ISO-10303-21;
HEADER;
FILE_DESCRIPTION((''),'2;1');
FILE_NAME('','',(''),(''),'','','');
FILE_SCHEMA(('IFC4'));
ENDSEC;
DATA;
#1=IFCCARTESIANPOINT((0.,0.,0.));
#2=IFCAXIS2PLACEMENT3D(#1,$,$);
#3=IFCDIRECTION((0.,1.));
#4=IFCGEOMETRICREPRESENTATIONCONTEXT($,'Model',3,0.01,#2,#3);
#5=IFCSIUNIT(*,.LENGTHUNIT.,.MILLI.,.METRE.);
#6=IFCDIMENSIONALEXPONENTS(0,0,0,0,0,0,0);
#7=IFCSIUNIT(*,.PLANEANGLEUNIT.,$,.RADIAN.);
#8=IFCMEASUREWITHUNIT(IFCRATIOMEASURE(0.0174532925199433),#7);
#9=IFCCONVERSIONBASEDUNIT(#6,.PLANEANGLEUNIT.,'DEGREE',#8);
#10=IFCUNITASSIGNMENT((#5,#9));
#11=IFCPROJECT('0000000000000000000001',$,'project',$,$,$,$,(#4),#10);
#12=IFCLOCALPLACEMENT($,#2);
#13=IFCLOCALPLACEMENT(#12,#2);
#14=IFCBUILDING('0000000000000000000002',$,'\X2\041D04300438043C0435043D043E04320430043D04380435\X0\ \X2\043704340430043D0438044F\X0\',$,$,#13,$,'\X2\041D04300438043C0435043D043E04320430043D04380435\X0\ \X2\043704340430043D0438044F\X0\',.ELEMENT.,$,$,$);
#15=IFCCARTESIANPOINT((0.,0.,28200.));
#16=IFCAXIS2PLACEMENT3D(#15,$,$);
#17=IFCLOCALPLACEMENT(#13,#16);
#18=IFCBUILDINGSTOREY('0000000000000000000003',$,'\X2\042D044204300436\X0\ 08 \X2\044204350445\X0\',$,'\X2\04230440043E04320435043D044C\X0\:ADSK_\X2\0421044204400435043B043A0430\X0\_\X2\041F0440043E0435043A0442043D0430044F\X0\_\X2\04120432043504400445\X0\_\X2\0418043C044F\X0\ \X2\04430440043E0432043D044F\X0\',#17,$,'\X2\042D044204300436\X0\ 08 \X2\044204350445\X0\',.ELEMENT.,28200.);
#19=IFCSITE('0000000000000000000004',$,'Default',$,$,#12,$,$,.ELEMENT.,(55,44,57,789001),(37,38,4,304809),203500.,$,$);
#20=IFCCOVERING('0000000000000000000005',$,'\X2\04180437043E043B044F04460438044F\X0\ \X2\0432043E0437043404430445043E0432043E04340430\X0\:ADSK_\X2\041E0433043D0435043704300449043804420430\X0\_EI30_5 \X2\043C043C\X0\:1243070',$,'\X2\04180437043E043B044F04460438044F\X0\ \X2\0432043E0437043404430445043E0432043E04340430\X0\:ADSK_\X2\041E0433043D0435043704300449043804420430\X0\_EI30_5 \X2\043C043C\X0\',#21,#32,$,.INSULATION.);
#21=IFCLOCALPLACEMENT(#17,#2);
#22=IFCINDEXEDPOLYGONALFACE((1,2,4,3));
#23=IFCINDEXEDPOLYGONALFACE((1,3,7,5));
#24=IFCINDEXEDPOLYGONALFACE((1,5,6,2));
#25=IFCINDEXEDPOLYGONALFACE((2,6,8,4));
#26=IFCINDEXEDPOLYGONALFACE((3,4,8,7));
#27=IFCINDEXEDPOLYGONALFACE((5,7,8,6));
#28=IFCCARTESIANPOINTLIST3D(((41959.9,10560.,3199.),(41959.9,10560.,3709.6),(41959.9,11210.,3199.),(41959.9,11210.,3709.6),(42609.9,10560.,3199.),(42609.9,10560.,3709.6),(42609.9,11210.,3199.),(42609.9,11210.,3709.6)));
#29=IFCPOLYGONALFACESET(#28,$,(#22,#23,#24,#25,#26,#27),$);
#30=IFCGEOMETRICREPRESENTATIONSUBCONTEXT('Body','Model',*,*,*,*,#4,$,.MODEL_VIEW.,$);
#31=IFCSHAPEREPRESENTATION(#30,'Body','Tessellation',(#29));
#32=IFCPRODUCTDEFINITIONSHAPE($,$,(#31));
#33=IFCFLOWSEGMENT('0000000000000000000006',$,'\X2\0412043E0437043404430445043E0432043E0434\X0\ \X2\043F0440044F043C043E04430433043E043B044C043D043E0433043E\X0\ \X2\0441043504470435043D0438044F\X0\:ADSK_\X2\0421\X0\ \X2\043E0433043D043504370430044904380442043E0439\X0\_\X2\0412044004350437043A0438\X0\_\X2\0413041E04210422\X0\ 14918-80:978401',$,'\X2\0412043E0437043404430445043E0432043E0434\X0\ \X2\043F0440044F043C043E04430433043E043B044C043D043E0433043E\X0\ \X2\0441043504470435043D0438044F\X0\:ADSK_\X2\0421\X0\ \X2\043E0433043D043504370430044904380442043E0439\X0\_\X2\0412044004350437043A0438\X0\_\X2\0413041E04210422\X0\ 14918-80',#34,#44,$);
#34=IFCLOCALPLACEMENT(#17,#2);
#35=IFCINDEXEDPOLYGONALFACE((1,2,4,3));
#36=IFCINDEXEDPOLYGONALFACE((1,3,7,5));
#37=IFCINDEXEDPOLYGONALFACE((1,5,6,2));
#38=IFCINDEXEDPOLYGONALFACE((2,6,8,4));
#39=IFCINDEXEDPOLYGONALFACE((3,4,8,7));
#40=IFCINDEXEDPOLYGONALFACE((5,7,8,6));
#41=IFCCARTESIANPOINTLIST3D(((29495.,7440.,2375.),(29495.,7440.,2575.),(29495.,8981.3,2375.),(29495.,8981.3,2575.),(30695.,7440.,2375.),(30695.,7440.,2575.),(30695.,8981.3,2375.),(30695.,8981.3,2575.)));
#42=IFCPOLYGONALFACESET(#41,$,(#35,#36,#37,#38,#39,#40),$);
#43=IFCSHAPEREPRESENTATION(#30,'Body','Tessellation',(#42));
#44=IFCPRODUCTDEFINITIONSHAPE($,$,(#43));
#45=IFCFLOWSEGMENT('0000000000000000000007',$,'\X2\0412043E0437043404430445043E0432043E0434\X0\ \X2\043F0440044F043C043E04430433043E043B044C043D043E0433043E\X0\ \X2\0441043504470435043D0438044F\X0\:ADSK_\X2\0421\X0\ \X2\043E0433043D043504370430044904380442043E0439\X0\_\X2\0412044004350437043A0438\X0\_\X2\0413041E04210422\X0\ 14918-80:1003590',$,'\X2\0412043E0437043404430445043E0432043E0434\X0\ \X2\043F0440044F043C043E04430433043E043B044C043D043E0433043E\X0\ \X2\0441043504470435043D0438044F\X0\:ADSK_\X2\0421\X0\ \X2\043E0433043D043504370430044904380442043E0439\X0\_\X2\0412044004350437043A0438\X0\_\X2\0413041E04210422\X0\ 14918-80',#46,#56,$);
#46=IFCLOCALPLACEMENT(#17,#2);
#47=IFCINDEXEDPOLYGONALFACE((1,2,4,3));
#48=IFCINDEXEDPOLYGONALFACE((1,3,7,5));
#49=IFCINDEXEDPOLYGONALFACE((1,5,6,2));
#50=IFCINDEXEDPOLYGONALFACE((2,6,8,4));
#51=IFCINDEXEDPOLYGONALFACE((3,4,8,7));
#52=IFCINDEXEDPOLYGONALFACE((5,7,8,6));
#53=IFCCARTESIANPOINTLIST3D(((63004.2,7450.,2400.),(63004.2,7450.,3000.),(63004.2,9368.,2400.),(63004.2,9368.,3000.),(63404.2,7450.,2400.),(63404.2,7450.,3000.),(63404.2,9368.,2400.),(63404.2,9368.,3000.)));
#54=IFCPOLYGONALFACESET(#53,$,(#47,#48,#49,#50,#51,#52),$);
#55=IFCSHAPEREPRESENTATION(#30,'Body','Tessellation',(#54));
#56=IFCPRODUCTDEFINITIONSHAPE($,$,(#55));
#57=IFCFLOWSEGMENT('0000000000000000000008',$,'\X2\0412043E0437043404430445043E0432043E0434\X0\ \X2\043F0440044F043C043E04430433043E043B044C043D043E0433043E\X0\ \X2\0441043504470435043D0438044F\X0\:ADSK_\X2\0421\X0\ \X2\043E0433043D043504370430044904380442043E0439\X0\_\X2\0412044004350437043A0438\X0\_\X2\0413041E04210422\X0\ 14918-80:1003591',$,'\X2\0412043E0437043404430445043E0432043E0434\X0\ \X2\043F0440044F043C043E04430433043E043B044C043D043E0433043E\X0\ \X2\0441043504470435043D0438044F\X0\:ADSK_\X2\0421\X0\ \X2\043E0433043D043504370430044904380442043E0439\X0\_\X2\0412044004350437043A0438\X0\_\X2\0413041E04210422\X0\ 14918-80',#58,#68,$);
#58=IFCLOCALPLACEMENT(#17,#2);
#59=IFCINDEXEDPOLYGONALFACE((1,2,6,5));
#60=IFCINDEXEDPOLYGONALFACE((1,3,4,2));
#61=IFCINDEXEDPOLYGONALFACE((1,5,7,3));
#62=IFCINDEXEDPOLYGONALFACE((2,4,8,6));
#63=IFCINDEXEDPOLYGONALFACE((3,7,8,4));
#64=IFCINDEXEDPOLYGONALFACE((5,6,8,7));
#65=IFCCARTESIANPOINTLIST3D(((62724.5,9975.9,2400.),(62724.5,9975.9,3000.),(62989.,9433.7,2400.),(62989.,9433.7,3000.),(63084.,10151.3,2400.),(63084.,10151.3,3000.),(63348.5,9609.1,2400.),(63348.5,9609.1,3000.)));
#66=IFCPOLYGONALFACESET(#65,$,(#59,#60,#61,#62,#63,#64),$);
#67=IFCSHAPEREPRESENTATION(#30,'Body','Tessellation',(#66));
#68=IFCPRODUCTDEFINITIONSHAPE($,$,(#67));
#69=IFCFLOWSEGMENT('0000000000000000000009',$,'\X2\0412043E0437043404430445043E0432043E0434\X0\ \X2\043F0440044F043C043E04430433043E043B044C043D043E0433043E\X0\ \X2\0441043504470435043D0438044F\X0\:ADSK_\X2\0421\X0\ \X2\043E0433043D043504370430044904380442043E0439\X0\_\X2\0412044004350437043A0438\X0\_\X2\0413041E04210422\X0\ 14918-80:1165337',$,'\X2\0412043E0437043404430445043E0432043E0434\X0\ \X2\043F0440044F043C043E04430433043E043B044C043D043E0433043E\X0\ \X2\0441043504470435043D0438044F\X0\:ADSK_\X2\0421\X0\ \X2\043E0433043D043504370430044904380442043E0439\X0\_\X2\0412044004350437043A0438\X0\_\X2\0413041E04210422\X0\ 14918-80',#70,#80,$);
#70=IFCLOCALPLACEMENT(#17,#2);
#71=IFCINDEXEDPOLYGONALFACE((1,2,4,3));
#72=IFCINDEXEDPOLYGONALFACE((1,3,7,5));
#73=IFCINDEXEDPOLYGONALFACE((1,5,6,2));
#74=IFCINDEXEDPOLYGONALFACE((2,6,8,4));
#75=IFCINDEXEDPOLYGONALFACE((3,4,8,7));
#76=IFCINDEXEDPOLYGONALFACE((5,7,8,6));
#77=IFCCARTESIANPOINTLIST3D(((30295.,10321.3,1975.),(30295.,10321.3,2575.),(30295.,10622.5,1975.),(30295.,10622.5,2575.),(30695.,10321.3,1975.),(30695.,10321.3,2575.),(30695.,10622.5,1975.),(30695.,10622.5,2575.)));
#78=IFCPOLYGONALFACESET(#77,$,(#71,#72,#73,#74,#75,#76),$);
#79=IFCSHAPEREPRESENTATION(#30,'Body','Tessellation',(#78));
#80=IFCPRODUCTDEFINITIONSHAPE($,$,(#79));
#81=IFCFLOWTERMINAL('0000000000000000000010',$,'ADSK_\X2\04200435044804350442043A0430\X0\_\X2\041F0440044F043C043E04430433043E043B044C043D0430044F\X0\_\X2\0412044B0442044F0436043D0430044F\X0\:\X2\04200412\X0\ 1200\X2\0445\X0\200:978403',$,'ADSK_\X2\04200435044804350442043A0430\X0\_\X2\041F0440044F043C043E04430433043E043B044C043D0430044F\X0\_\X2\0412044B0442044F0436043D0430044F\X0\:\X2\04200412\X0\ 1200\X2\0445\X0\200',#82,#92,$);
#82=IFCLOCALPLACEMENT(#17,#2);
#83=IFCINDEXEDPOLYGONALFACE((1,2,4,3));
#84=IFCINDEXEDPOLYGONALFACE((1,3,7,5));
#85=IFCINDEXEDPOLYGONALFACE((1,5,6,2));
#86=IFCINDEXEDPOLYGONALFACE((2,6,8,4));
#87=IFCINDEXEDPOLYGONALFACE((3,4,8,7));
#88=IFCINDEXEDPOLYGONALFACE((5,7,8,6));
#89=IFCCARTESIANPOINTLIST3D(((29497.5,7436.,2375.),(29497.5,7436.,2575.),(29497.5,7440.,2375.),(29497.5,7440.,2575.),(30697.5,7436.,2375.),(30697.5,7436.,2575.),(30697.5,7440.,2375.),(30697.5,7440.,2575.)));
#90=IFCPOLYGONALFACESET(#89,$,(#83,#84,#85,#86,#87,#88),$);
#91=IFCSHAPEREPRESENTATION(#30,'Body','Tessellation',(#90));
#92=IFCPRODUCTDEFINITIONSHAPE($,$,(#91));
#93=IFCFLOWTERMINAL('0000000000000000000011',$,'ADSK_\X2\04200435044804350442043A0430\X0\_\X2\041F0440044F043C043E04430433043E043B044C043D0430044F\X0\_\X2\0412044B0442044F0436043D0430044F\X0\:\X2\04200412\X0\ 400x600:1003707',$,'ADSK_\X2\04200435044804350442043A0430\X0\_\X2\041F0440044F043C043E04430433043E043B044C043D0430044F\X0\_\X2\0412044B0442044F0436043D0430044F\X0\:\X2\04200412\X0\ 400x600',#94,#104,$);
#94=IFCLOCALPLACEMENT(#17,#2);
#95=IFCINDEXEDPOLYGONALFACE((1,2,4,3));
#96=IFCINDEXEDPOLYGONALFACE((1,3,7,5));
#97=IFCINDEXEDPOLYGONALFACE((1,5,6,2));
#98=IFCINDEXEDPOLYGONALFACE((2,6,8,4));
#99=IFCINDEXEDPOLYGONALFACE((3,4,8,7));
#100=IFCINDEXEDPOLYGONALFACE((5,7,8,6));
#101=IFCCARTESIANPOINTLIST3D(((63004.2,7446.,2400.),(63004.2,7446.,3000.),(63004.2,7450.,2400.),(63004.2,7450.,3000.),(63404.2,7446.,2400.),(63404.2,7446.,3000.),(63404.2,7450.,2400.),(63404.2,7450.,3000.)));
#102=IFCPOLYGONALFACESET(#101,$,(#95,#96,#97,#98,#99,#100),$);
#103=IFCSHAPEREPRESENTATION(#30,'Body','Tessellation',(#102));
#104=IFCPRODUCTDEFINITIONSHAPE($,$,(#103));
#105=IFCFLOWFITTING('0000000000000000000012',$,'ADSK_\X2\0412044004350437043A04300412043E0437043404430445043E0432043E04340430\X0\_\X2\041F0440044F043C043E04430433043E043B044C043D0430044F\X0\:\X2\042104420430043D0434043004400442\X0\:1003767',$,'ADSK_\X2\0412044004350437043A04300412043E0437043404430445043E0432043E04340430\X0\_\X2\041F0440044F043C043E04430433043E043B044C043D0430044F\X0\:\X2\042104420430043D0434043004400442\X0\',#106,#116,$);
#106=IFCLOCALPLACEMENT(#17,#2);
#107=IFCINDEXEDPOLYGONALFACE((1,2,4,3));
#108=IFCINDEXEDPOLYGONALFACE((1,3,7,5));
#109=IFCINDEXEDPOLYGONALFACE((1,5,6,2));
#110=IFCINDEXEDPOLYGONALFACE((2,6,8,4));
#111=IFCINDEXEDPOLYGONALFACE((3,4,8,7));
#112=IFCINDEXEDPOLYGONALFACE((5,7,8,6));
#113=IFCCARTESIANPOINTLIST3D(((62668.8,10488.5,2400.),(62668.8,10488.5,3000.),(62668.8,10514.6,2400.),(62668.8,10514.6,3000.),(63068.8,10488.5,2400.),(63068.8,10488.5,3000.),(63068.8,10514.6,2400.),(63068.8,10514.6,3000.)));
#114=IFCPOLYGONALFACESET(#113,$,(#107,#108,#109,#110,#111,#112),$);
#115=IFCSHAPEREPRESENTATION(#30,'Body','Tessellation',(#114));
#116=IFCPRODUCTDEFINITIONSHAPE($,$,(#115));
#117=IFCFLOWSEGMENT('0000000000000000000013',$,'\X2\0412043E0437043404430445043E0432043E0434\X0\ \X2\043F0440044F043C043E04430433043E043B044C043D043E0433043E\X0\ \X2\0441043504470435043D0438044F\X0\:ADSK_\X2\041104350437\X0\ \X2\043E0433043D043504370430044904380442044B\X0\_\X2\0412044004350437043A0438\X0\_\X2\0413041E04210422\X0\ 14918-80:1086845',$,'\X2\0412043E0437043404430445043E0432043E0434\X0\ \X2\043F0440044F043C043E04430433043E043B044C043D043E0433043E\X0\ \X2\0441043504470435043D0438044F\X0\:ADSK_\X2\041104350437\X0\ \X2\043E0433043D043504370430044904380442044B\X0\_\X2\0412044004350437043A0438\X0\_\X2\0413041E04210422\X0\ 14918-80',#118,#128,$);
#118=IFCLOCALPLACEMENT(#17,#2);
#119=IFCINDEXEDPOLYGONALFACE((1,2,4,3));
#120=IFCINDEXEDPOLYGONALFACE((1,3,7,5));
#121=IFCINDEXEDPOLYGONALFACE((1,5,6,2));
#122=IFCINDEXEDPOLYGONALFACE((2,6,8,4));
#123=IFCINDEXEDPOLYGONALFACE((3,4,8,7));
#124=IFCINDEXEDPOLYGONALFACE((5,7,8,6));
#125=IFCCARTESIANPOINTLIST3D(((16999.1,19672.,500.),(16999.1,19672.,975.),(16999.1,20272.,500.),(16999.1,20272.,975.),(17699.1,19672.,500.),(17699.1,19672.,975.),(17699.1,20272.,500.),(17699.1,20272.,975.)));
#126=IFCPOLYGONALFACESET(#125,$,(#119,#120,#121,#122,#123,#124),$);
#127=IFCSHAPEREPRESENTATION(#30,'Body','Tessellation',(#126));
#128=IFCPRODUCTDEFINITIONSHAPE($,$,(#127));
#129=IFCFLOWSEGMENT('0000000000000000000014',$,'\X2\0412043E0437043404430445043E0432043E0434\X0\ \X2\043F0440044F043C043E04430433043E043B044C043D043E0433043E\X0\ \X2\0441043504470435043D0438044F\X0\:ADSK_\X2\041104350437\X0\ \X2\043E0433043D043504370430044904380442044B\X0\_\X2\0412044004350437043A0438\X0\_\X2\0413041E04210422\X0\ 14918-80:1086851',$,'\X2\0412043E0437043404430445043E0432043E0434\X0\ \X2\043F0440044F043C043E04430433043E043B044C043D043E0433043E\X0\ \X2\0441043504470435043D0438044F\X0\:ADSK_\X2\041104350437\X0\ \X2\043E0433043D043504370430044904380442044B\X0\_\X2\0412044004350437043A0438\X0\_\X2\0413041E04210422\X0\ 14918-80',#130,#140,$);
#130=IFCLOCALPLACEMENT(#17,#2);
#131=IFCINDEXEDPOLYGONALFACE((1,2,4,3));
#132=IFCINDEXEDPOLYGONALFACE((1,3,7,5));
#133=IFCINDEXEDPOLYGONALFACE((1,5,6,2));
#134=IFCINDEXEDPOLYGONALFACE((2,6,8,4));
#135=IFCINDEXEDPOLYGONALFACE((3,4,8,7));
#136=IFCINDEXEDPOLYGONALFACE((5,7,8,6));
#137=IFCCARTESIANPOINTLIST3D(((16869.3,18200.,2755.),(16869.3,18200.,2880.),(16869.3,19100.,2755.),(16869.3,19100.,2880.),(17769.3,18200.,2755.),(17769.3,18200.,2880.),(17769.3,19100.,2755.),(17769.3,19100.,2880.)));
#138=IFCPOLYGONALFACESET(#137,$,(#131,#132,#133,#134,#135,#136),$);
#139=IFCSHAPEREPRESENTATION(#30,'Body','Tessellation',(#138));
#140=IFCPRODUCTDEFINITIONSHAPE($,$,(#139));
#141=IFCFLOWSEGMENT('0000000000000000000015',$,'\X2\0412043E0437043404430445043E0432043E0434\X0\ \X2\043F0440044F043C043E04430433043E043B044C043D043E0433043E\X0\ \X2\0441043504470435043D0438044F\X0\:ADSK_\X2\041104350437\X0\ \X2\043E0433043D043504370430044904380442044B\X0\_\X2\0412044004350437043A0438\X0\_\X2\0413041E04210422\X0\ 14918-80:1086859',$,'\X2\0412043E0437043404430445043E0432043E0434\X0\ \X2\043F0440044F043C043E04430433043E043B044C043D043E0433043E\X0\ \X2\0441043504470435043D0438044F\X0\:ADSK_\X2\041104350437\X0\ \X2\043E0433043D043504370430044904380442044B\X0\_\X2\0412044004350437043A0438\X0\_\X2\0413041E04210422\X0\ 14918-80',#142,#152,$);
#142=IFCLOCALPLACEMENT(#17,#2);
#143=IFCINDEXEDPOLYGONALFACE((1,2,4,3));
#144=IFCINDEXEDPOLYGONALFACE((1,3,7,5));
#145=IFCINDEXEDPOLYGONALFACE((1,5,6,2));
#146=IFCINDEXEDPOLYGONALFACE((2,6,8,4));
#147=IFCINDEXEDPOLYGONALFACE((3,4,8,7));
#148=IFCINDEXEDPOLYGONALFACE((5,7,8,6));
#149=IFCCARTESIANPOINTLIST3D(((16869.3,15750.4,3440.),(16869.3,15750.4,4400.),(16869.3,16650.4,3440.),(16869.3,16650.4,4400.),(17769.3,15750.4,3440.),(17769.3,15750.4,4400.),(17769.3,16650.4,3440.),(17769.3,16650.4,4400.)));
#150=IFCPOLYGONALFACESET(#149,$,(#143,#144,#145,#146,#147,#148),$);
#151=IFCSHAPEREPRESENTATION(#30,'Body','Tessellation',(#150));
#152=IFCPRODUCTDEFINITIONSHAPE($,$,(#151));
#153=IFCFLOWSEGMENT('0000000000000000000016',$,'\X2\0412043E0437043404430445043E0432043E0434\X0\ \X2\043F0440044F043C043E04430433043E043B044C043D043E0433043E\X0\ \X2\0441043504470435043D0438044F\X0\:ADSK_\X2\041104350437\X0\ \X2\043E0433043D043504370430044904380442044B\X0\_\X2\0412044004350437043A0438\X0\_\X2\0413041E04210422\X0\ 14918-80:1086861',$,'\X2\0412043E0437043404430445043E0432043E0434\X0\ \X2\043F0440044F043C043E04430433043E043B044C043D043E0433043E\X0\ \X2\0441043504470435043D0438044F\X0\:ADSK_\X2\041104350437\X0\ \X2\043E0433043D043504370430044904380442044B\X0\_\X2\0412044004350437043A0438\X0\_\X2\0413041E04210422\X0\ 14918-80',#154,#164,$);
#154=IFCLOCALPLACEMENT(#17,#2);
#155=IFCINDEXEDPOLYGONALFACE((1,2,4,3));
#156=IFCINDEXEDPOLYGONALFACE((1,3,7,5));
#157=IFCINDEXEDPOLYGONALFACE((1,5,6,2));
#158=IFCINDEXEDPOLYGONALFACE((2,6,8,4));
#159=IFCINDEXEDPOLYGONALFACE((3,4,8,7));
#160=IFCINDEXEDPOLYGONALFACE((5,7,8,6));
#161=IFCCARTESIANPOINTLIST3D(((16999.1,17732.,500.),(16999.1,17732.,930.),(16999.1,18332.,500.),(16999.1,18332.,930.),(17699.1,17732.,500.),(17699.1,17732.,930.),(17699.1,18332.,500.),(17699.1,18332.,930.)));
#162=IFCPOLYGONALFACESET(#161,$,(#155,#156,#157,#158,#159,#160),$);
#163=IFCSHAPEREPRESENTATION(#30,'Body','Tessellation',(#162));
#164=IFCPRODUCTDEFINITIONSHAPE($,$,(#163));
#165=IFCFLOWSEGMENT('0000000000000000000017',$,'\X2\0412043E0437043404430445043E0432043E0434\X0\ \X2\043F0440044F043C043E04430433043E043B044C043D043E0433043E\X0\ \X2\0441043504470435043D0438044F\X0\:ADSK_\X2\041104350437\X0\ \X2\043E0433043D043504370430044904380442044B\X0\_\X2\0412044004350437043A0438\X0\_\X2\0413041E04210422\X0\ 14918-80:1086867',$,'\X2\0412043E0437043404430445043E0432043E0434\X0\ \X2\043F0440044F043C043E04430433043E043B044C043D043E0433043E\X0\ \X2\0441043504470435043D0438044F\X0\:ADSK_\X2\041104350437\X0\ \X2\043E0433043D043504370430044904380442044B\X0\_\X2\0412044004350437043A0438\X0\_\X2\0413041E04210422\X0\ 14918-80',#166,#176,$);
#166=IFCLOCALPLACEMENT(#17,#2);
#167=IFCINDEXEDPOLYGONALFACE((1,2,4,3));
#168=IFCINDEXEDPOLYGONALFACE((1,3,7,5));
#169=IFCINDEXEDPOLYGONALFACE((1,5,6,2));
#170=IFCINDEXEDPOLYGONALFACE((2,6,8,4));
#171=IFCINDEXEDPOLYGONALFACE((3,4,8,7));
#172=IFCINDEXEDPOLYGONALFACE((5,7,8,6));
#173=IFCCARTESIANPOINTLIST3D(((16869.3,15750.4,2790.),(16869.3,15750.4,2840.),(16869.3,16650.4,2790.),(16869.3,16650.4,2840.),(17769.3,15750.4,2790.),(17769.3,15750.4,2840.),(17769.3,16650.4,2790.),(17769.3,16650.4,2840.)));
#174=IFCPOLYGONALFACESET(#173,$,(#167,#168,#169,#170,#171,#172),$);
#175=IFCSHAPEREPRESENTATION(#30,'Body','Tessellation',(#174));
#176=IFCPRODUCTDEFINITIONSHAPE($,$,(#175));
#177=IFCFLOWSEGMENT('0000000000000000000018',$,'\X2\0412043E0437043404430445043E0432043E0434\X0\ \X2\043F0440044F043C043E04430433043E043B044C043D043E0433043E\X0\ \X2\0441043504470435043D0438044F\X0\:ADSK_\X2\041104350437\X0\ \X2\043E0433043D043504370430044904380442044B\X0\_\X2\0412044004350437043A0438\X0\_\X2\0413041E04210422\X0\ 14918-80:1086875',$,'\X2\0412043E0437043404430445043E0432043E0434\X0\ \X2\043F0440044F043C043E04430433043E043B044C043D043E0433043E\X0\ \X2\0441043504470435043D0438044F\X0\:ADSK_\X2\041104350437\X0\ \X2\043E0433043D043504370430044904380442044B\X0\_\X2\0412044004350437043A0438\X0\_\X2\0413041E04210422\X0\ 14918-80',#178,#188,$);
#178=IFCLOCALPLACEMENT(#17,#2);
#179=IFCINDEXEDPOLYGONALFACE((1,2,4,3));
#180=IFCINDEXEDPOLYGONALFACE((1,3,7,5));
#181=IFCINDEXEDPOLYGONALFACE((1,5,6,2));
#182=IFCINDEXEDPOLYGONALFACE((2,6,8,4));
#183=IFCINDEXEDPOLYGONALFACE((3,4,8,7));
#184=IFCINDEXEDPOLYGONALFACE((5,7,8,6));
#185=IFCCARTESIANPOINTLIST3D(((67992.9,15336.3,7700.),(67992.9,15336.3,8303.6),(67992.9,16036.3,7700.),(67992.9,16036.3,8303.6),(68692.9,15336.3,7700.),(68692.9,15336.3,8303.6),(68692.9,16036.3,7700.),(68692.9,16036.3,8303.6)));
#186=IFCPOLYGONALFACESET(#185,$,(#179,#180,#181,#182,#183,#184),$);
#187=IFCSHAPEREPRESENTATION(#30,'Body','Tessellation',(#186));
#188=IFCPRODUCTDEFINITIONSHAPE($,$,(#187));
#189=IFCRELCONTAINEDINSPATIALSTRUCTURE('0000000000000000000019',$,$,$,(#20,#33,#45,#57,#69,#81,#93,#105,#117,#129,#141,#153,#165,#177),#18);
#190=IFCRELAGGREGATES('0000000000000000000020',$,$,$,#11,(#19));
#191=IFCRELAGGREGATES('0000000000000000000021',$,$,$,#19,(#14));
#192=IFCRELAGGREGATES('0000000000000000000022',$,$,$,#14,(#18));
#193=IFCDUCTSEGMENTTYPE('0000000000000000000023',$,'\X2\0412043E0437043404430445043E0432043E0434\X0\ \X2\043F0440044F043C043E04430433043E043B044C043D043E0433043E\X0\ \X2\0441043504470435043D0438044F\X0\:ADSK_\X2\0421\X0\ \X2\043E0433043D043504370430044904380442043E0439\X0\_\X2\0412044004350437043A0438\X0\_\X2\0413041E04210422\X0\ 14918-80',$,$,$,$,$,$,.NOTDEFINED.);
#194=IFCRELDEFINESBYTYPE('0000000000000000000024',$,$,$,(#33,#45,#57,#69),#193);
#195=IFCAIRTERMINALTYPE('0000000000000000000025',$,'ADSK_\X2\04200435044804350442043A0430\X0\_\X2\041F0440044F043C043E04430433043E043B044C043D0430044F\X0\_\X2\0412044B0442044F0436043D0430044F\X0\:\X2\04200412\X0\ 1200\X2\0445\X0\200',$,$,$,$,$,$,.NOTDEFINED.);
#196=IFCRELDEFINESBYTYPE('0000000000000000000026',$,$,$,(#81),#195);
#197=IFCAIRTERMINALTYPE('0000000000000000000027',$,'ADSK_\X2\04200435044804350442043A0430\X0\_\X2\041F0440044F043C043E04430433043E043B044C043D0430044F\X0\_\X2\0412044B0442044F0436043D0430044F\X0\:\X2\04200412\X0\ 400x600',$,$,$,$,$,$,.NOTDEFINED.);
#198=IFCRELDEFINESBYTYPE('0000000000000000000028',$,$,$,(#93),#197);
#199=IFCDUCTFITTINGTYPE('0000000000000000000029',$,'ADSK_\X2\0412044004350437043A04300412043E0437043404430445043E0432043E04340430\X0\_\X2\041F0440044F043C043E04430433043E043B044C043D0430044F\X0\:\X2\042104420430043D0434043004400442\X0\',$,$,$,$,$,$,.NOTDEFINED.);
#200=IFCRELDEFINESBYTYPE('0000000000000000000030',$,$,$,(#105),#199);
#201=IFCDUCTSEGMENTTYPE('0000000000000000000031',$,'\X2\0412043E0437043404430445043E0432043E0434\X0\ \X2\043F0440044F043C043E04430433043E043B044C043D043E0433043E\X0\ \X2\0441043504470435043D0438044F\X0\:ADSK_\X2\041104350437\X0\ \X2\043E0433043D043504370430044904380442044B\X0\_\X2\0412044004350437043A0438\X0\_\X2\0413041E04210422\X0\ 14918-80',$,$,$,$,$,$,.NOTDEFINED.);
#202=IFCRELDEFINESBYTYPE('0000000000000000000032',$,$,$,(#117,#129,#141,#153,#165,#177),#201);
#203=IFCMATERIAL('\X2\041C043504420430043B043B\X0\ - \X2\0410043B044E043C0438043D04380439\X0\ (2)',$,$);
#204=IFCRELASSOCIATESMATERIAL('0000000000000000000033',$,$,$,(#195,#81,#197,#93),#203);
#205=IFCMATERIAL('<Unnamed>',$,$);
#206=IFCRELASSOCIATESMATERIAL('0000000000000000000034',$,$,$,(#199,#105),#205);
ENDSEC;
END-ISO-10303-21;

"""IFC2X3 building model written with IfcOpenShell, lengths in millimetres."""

from ifc_helpers import new_model, entity, si_unit, converted_unit, direction, frame, frame_2d, origin, origin_2d_with_axis, place, context, subcontext, project, spatial, rectangle, extrude, source, transform, mapped, material, type_object, type_shapes, element, save


model = new_model("IFC2X3")

# Units and contexts
model_context = context("Model", 3, precision=0.01, world=origin(), true_north=direction((0.0, 1.0)))
body_context = subcontext(model_context, "Body", "Model", "MODEL_VIEW")
ifc_project = project(units=[si_unit("LENGTHUNIT", "METRE", prefix="MILLI"), converted_unit("PLANEANGLEUNIT", "DEGREE", entity("IfcRatioMeasure", 0.0174532925199433), si_unit("PLANEANGLEUNIT", "RADIAN"), dimensions=[0, 0, 0, 0, 0, 0, 0])], contexts=[model_context])

# Site, building, storey
site_placement = place(None, frame((0.0, 0.0, 0.0)))
site = spatial("IfcSite", under=ifc_project, at=site_placement, Name="Default", CompositionType="ELEMENT", RefLatitude=(55, 44, 57, 789001), RefLongitude=(37, 38, 4, 304809), RefElevation=203500.0)
building_placement = place(site_placement, origin())
building = spatial("IfcBuilding", under=site, at=building_placement, Name="Наименование здания", LongName="Наименование здания", CompositionType="ELEMENT")
storey_placement = place(building_placement, frame((0.0, 0.0, 28200.0)))
storey = spatial("IfcBuildingStorey", under=building, at=storey_placement, Name="Этаж 08 тех", ObjectType="Уровень:ADSK_Стрелка_Проектная_Вверх_Имя уровня", LongName="Этаж 08 тех", CompositionType="ELEMENT", Elevation=28200.0)

# Covering
covering_1_placement = place(storey_placement, frame((41959.9, 10560.0, 3199.0)))
element("IfcCovering", 1, at=covering_1_placement, inside=storey, Name="Изоляция воздуховода:ADSK_Огнезащита_EI30_5 мм:1243070", ObjectType="Изоляция воздуховода:ADSK_Огнезащита_EI30_5 мм", PredefinedType="INSULATION", context=body_context, shape_type="SweptSolid", body=[
    extrude(rectangle(XDim=650.0, YDim=650.0, at=origin_2d_with_axis()), frame((325.0, 325.0, 0.0), z_axis=(0.0, 0.0, 1.0), x_axis=(-1.0, 0.0, 0.0)), (0.0, 0.0, 1.0), 510.6),
])

# Flow segments
duct_segment_type_1 = type_object("IfcDuctSegmentType", Name="Воздуховод прямоугольного сечения:ADSK_С огнезащитой_Врезки_ГОСТ 14918-80", PredefinedType="NOTDEFINED")
flow_segment_1_placement = place(storey_placement, frame((29495.0, 7440.0, 2375.0)))
element("IfcFlowSegment", 2, at=flow_segment_1_placement, inside=storey, type_object=duct_segment_type_1, Name="Воздуховод прямоугольного сечения:ADSK_С огнезащитой_Врезки_ГОСТ 14918-80:978401", ObjectType="Воздуховод прямоугольного сечения:ADSK_С огнезащитой_Врезки_ГОСТ 14918-80", context=body_context, shape_type="SweptSolid", body=[
    extrude(rectangle(XDim=1541.3, YDim=1200.0, at=frame_2d((0.0, 0.0), x_axis=(1.0, 0.0))), frame((600.0, 770.6, 0.0), z_axis=(0.0, 0.0, 1.0), x_axis=(0.0, 1.0, 0.0)), (0.0, 0.0, 1.0), 200.0),
])
flow_segment_2_placement = place(storey_placement, frame((63004.2, 7450.0, 2400.0)))
element("IfcFlowSegment", 3, at=flow_segment_2_placement, inside=storey, type_object=duct_segment_type_1, Name="Воздуховод прямоугольного сечения:ADSK_С огнезащитой_Врезки_ГОСТ 14918-80:1003590", ObjectType="Воздуховод прямоугольного сечения:ADSK_С огнезащитой_Врезки_ГОСТ 14918-80", context=body_context, shape_type="SweptSolid", body=[
    extrude(rectangle(XDim=1918.0, YDim=400.0, at=frame_2d((0.0, 0.0), x_axis=(1.0, 0.0))), frame((200.0, 959.0, 0.0), z_axis=(0.0, 0.0, 1.0), x_axis=(0.0, -1.0, 0.0)), (0.0, 0.0, 1.0), 600.0),
])
flow_segment_3_placement = place(storey_placement, frame((62724.5, 9433.7, 2400.0)))
element("IfcFlowSegment", 4, at=flow_segment_3_placement, inside=storey, type_object=duct_segment_type_1, Name="Воздуховод прямоугольного сечения:ADSK_С огнезащитой_Врезки_ГОСТ 14918-80:1003591", ObjectType="Воздуховод прямоугольного сечения:ADSK_С огнезащитой_Врезки_ГОСТ 14918-80", context=body_context, shape_type="SweptSolid", body=[
    extrude(rectangle(XDim=603.3, YDim=400.0, at=frame_2d((0.0, 0.0), x_axis=(1.0, 0.0))), frame((312.0, 358.8, 0.0), z_axis=(0.0, 0.0, 1.0), x_axis=(-0.438371, 0.898794, 0.0)), (0.0, 0.0, 1.0), 600.0),
])
flow_segment_4_placement = place(storey_placement, frame((30295.0, 10321.3, 1975.0)))
element("IfcFlowSegment", 5, at=flow_segment_4_placement, inside=storey, type_object=duct_segment_type_1, Name="Воздуховод прямоугольного сечения:ADSK_С огнезащитой_Врезки_ГОСТ 14918-80:1165337", ObjectType="Воздуховод прямоугольного сечения:ADSK_С огнезащитой_Врезки_ГОСТ 14918-80", context=body_context, shape_type="SweptSolid", body=[
    extrude(rectangle(XDim=301.2, YDim=400.0, at=frame_2d((0.0, 0.0), x_axis=(1.0, 0.0))), frame((200.0, 150.6, 0.0), z_axis=(0.0, 0.0, 1.0), x_axis=(0.0, 1.0, 0.0)), (0.0, 0.0, 1.0), 600.0),
])

# Flow terminal
ifc_material_1 = material(Name="Металл - Алюминий (2)")
air_terminal_type_1 = type_object("IfcAirTerminalType", Name="ADSK_Решетка_Прямоугольная_Вытяжная:РВ 1200х200", PredefinedType="NOTDEFINED", material=ifc_material_1)
shared_shape_1 = source(origin(), body_context, "Body", "SweptSolid", [
    extrude(rectangle(XDim=4.0, YDim=1200.0, at=origin_2d_with_axis()), frame((0.0, -2.0, -100.0), z_axis=(0.0, 0.0, 1.0), x_axis=(0.0, 1.0, 0.0)), (0.0, 0.0, 1.0), 200.0),
])
type_shapes(air_terminal_type_1, [shared_shape_1])
flow_terminal_1_placement = place(storey_placement, frame((30097.5, 7440.0, 2475.0)))
element("IfcFlowTerminal", 6, at=flow_terminal_1_placement, inside=storey, type_object=air_terminal_type_1, material=ifc_material_1, Name="ADSK_Решетка_Прямоугольная_Вытяжная:РВ 1200х200:978403", ObjectType="ADSK_Решетка_Прямоугольная_Вытяжная:РВ 1200х200", context=body_context, shape_type="MappedRepresentation", body=[
    mapped(shared_shape_1, transform((0.0, 0.0, 0.0), scale=1.0)),
])

# Shared definitions
ifc_material_2 = material(Name="<Unnamed>")

# Flow terminal
air_terminal_type_2 = type_object("IfcAirTerminalType", Name="ADSK_Решетка_Прямоугольная_Вытяжная:РВ 400x600", PredefinedType="NOTDEFINED", material=ifc_material_1)
shared_shape_2 = source(origin(), body_context, "Body", "SweptSolid", [
    extrude(rectangle(XDim=4.0, YDim=400.0, at=origin_2d_with_axis()), frame((0.0, -2.0, -300.0), z_axis=(0.0, 0.0, 1.0), x_axis=(0.0, 1.0, 0.0)), (0.0, 0.0, 1.0), 600.0),
])
type_shapes(air_terminal_type_2, [shared_shape_2])
flow_terminal_2_placement = place(storey_placement, frame((63204.2, 7450.0, 2700.0)))
element("IfcFlowTerminal", 7, at=flow_terminal_2_placement, inside=storey, type_object=air_terminal_type_2, material=ifc_material_1, Name="ADSK_Решетка_Прямоугольная_Вытяжная:РВ 400x600:1003707", ObjectType="ADSK_Решетка_Прямоугольная_Вытяжная:РВ 400x600", context=body_context, shape_type="MappedRepresentation", body=[
    mapped(shared_shape_2, transform((0.0, 0.0, 0.0), scale=1.0)),
])

# Flow fitting
duct_fitting_type_1 = type_object("IfcDuctFittingType", Name="ADSK_ВрезкаВоздуховода_Прямоугольная:Стандарт", PredefinedType="NOTDEFINED", material=ifc_material_2)
shared_shape_3 = source(origin(), body_context, "Body", "SweptSolid", [
    extrude(rectangle(XDim=600.0, YDim=26.1, at=origin_2d_with_axis()), frame((7.0, 0.0, -200.0), z_axis=(0.0, 0.0, 1.0), x_axis=(0.0, -1.0, 0.0)), (0.0, 0.0, 1.0), 400.0),
])
type_shapes(duct_fitting_type_1, [shared_shape_3])
flow_fitting_1_placement = place(storey_placement, frame((62868.8, 10508.5, 2700.0), z_axis=(-1.0, 0.0, 0.0), x_axis=(0.0, -1.0, 0.0)))
element("IfcFlowFitting", 8, at=flow_fitting_1_placement, inside=storey, type_object=duct_fitting_type_1, material=ifc_material_2, Name="ADSK_ВрезкаВоздуховода_Прямоугольная:Стандарт:1003767", ObjectType="ADSK_ВрезкаВоздуховода_Прямоугольная:Стандарт", context=body_context, shape_type="MappedRepresentation", body=[
    mapped(shared_shape_3, transform((0.0, 0.0, 0.0), scale=1.0)),
])

# Flow segments
duct_segment_type_2 = type_object("IfcDuctSegmentType", Name="Воздуховод прямоугольного сечения:ADSK_Без огнезащиты_Врезки_ГОСТ 14918-80", PredefinedType="NOTDEFINED")
flow_segment_5_placement = place(storey_placement, frame((16999.1, 19672.0, 500.0)))
element("IfcFlowSegment", 9, at=flow_segment_5_placement, inside=storey, type_object=duct_segment_type_2, Name="Воздуховод прямоугольного сечения:ADSK_Без огнезащиты_Врезки_ГОСТ 14918-80:1086845", ObjectType="Воздуховод прямоугольного сечения:ADSK_Без огнезащиты_Врезки_ГОСТ 14918-80", context=body_context, shape_type="SweptSolid", body=[
    extrude(rectangle(XDim=700.0, YDim=600.0, at=frame_2d((0.0, 0.0), x_axis=(1.0, 0.0))), frame((350.0, 300.0, 0.0), z_axis=(0.0, 0.0, 1.0), x_axis=(-1.0, 0.0, 0.0)), (0.0, 0.0, 1.0), 475.0),
])
flow_segment_6_placement = place(storey_placement, frame((16869.3, 18200.0, 2755.0)))
element("IfcFlowSegment", 10, at=flow_segment_6_placement, inside=storey, type_object=duct_segment_type_2, Name="Воздуховод прямоугольного сечения:ADSK_Без огнезащиты_Врезки_ГОСТ 14918-80:1086851", ObjectType="Воздуховод прямоугольного сечения:ADSK_Без огнезащиты_Врезки_ГОСТ 14918-80", context=body_context, shape_type="SweptSolid", body=[
    extrude(rectangle(XDim=900.0, YDim=900.0, at=frame_2d((0.0, 0.0), x_axis=(1.0, 0.0))), frame((450.0, 450.0, 0.0)), (0.0, 0.0, 1.0), 125.0),
])
flow_segment_7_placement = place(storey_placement, frame((16869.3, 15750.4, 3440.0)))
element("IfcFlowSegment", 11, at=flow_segment_7_placement, inside=storey, type_object=duct_segment_type_2, Name="Воздуховод прямоугольного сечения:ADSK_Без огнезащиты_Врезки_ГОСТ 14918-80:1086859", ObjectType="Воздуховод прямоугольного сечения:ADSK_Без огнезащиты_Врезки_ГОСТ 14918-80", context=body_context, shape_type="SweptSolid", body=[
    extrude(rectangle(XDim=900.0, YDim=900.0, at=frame_2d((0.0, 0.0), x_axis=(1.0, 0.0))), frame((450.0, 450.0, 0.0)), (0.0, 0.0, 1.0), 960.0),
])
flow_segment_8_placement = place(storey_placement, frame((16999.1, 17732.0, 500.0)))
element("IfcFlowSegment", 12, at=flow_segment_8_placement, inside=storey, type_object=duct_segment_type_2, Name="Воздуховод прямоугольного сечения:ADSK_Без огнезащиты_Врезки_ГОСТ 14918-80:1086861", ObjectType="Воздуховод прямоугольного сечения:ADSK_Без огнезащиты_Врезки_ГОСТ 14918-80", context=body_context, shape_type="SweptSolid", body=[
    extrude(rectangle(XDim=700.0, YDim=600.0, at=frame_2d((0.0, 0.0), x_axis=(1.0, 0.0))), frame((350.0, 300.0, 0.0)), (0.0, 0.0, 1.0), 430.0),
])
flow_segment_9_placement = place(storey_placement, frame((16869.3, 15750.4, 2790.0)))
element("IfcFlowSegment", 13, at=flow_segment_9_placement, inside=storey, type_object=duct_segment_type_2, Name="Воздуховод прямоугольного сечения:ADSK_Без огнезащиты_Врезки_ГОСТ 14918-80:1086867", ObjectType="Воздуховод прямоугольного сечения:ADSK_Без огнезащиты_Врезки_ГОСТ 14918-80", context=body_context, shape_type="SweptSolid", body=[
    extrude(rectangle(XDim=900.0, YDim=900.0, at=origin_2d_with_axis()), frame((450.0, 450.0, 0.0)), (0.0, 0.0, 1.0), 50.0),
])
flow_segment_10_placement = place(storey_placement, frame((67992.9, 15336.3, 7700.0)))
element("IfcFlowSegment", 14, at=flow_segment_10_placement, inside=storey, type_object=duct_segment_type_2, Name="Воздуховод прямоугольного сечения:ADSK_Без огнезащиты_Врезки_ГОСТ 14918-80:1086875", ObjectType="Воздуховод прямоугольного сечения:ADSK_Без огнезащиты_Врезки_ГОСТ 14918-80", context=body_context, shape_type="SweptSolid", body=[
    extrude(rectangle(XDim=700.0, YDim=700.0, at=frame_2d((0.0, 0.0), x_axis=(1.0, 0.0))), frame((350.0, 350.0, 0.0)), (0.0, 0.0, 1.0), 603.6),
])

save(model, "model.ifc")
